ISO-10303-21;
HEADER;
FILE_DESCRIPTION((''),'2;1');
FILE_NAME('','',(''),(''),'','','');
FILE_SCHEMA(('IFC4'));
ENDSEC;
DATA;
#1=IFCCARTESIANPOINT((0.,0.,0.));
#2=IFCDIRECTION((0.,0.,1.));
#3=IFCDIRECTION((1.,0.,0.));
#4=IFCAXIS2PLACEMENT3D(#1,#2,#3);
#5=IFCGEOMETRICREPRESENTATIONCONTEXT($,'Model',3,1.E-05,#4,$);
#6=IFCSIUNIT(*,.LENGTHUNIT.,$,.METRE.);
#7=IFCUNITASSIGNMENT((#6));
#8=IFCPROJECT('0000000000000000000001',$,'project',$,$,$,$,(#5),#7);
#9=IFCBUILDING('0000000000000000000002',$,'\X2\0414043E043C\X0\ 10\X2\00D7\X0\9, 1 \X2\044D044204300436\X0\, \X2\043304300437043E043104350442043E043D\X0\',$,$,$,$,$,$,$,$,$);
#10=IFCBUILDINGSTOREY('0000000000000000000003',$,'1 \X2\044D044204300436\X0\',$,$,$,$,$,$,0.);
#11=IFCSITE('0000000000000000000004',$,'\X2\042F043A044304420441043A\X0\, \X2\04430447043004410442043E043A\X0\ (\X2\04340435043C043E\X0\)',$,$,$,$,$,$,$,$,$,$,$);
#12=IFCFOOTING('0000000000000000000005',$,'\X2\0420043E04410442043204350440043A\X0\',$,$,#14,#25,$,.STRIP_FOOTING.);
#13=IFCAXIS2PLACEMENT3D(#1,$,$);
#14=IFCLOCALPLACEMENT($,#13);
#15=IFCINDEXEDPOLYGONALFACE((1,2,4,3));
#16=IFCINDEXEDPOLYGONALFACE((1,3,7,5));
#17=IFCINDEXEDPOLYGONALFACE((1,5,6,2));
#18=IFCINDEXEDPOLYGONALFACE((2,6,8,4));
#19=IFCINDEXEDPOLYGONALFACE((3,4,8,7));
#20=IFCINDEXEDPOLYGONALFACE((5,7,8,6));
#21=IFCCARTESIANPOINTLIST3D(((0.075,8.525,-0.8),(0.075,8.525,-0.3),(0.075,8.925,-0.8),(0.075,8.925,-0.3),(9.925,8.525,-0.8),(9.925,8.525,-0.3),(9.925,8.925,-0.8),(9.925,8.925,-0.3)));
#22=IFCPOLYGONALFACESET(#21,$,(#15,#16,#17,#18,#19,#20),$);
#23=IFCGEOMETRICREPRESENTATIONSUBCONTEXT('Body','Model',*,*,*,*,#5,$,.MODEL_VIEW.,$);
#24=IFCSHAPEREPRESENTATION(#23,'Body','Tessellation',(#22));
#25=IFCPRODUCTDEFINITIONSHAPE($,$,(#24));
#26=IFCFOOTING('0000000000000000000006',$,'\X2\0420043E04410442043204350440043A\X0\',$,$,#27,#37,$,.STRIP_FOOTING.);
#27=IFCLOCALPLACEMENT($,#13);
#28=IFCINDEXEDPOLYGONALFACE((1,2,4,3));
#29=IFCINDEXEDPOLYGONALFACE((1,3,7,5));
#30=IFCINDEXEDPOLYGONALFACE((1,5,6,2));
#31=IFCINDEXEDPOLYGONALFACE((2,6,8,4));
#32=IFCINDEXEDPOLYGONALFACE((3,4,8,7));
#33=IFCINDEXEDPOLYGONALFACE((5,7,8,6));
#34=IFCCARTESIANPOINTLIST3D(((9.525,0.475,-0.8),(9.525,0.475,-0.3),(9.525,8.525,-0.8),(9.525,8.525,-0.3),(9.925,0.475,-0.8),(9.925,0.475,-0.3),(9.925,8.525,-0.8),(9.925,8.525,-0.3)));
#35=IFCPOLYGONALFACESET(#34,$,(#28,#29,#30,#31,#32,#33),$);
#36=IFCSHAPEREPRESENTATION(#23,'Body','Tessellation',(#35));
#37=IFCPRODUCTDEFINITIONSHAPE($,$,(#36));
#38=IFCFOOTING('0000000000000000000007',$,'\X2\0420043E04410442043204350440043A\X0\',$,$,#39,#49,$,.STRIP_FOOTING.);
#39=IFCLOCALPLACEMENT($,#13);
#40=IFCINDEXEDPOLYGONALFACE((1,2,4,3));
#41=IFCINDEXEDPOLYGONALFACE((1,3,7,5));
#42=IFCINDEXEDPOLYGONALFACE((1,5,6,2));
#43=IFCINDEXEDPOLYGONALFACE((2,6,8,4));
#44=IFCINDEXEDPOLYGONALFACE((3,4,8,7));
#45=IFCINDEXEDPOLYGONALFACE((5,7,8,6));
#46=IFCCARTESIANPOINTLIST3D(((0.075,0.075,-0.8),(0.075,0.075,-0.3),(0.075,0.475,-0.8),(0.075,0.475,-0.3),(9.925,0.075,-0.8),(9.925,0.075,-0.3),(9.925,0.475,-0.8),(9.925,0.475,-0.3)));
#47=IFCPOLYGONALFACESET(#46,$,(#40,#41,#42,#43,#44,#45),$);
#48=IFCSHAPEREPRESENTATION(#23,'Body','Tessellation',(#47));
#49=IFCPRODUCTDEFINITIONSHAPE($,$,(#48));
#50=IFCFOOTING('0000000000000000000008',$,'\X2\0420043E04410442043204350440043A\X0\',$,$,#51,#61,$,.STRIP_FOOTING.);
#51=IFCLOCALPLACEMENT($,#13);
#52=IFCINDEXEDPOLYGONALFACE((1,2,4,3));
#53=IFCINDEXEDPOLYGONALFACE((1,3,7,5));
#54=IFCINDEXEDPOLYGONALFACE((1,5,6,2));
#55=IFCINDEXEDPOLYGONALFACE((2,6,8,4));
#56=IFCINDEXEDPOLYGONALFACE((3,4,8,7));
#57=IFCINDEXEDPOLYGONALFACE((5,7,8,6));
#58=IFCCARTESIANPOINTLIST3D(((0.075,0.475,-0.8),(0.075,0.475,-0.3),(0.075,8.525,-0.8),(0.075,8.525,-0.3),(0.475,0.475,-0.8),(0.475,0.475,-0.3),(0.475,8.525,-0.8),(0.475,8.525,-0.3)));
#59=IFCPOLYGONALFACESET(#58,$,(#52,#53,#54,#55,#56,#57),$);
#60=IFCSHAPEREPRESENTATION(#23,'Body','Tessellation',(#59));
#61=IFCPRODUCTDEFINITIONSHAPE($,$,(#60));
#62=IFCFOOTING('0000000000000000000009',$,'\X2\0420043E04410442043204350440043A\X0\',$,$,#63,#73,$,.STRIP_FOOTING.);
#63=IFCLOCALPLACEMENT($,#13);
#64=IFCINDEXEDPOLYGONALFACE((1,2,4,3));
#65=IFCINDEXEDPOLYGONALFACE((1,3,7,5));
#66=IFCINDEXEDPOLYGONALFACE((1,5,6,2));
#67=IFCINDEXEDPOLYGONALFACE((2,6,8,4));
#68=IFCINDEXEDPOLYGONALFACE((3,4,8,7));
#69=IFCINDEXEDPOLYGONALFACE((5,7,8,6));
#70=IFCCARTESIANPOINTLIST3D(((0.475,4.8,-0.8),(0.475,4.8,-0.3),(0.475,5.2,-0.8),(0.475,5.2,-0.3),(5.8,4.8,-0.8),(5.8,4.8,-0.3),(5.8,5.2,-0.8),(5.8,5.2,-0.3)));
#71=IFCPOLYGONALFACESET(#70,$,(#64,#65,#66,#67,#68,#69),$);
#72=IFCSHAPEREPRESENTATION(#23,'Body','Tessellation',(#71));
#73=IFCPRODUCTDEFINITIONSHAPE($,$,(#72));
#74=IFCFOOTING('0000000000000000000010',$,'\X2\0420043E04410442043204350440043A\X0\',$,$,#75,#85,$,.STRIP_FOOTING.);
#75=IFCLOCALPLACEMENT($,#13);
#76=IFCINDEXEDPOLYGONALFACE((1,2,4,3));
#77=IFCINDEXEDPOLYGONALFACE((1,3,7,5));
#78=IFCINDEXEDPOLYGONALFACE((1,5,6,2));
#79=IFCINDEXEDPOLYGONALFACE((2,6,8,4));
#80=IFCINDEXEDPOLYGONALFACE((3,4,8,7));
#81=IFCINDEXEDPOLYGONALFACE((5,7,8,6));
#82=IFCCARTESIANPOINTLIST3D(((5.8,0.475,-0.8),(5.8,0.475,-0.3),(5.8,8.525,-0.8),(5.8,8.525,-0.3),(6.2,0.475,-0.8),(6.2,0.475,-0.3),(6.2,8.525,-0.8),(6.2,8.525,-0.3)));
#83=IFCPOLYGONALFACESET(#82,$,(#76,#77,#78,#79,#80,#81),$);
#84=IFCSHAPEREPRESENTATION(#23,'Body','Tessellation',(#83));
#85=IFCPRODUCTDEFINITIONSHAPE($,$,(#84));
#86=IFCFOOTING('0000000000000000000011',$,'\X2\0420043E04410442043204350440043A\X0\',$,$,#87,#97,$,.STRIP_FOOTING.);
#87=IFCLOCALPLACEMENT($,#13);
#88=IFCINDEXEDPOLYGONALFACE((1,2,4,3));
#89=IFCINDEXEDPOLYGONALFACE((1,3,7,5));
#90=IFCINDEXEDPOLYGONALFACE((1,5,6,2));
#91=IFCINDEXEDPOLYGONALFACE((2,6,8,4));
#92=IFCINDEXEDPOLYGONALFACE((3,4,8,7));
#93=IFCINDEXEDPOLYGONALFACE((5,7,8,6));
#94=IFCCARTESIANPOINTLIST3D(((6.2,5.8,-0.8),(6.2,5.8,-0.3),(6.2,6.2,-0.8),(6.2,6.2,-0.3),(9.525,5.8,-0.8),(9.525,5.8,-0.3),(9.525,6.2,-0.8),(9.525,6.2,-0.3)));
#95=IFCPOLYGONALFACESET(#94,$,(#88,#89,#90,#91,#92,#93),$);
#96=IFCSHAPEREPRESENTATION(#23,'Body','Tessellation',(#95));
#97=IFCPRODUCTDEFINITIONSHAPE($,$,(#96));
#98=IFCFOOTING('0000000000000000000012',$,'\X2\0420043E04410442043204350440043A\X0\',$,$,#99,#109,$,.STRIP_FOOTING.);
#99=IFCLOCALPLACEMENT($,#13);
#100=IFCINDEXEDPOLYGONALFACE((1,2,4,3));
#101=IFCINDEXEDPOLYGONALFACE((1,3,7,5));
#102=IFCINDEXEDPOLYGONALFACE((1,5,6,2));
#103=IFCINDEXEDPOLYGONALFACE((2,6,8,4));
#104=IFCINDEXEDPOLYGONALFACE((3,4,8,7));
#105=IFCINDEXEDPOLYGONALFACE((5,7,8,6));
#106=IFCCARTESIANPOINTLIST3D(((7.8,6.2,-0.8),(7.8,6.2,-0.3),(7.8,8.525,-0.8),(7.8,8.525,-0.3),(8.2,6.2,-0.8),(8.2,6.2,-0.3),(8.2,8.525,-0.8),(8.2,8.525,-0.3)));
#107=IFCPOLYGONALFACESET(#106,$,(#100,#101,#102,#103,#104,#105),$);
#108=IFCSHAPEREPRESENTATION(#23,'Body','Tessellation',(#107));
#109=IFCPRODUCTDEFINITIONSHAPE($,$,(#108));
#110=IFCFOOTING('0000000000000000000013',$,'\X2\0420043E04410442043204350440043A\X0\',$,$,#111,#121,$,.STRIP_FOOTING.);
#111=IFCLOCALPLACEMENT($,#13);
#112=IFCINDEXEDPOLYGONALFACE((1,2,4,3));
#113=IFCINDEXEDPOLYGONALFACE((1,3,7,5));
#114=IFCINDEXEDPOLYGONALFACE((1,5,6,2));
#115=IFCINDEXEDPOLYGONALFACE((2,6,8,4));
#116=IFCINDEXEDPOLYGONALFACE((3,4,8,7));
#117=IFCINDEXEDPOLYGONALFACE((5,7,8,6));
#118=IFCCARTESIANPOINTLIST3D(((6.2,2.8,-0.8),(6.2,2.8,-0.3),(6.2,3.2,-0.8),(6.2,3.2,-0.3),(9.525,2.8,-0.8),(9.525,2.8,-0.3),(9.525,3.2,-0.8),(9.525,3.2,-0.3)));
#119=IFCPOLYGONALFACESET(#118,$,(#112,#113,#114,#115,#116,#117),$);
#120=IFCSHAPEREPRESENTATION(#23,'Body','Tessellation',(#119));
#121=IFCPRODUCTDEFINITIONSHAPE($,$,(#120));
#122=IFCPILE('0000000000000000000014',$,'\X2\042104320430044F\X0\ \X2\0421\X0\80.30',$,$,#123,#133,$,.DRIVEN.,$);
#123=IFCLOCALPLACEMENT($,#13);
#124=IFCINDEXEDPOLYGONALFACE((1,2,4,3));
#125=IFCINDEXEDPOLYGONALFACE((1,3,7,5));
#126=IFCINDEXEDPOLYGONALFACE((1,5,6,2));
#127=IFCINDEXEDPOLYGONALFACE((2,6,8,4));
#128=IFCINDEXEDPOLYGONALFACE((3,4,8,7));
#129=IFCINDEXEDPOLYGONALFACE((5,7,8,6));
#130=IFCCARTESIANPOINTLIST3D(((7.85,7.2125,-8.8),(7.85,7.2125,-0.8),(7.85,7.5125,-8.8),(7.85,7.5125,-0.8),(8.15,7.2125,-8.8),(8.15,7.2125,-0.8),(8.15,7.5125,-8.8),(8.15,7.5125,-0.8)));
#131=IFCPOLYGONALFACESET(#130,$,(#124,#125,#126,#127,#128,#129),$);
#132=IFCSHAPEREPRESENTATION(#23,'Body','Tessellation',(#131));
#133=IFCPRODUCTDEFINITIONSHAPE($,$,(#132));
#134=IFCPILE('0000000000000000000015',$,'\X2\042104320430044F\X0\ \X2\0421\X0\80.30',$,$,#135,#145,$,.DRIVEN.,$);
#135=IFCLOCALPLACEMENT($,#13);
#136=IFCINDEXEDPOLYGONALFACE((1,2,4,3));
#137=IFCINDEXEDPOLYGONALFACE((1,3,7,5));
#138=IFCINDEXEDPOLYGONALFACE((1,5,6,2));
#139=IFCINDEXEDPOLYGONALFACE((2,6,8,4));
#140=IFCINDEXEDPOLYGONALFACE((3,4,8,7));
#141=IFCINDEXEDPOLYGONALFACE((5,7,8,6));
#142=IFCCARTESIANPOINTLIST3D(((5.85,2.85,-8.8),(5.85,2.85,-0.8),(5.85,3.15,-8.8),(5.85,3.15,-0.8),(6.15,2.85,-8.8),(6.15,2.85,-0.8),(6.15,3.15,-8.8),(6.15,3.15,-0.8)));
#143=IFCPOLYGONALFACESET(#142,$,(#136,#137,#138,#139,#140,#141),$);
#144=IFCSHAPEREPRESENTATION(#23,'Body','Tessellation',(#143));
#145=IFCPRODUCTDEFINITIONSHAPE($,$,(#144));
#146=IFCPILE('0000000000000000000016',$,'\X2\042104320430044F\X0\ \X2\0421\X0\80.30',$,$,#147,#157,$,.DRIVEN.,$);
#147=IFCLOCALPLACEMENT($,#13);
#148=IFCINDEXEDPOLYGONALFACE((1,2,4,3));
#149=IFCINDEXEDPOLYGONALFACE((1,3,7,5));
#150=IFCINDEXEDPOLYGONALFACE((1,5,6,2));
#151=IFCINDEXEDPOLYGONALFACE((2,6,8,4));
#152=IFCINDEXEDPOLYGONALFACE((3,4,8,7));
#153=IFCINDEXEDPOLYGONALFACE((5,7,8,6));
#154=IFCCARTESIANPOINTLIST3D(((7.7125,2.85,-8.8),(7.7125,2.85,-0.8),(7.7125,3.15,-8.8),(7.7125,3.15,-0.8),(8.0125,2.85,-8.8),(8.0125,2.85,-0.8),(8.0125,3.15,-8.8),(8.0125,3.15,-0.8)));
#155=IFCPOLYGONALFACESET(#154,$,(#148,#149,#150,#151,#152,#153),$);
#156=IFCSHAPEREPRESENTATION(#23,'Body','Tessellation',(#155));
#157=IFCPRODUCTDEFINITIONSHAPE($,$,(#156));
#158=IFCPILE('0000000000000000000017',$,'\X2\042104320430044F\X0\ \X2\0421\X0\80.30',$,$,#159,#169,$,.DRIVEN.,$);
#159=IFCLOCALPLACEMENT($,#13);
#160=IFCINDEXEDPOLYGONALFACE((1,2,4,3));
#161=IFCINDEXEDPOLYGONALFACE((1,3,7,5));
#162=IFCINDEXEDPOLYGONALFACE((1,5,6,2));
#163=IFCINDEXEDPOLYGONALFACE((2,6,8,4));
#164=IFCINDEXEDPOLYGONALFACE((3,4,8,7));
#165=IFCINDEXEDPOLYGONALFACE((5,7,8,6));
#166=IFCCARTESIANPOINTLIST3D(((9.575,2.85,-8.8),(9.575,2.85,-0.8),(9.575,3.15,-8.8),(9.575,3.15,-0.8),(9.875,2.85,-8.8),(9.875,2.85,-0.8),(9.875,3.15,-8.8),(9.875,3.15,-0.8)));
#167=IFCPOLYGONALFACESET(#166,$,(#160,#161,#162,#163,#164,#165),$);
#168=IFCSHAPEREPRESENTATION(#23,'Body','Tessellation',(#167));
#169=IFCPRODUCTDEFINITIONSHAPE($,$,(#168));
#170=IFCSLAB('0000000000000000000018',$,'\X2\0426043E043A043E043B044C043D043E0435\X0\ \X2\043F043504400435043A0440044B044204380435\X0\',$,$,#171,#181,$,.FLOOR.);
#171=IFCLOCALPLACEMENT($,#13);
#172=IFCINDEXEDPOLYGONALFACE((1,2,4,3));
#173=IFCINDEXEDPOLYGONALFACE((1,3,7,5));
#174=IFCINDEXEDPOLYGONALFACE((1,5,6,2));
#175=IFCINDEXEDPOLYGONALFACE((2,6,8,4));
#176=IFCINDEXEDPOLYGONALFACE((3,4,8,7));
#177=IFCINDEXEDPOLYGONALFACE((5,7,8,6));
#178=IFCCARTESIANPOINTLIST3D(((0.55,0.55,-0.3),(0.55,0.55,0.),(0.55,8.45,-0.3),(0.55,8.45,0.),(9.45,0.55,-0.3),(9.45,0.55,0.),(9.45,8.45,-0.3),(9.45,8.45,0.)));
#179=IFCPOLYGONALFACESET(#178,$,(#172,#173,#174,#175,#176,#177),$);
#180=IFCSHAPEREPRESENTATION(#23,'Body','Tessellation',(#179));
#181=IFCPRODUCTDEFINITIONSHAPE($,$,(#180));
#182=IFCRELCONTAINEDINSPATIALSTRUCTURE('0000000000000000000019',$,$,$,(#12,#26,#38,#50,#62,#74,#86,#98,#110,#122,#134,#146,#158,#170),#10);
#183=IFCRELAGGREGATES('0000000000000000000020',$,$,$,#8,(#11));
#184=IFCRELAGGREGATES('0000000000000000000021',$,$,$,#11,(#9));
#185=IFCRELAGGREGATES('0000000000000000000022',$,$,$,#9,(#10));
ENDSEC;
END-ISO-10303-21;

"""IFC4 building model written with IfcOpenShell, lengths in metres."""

from ifc_helpers import new_model, si_unit, frame, origin_with_axes, place, context, subcontext, project, spatial, indexed_curve, rectangle, outline, extrude, element, save


model = new_model("IFC4")

# Units and contexts
model_context = context("Model", 3, precision=1e-05, world=origin_with_axes())
body_context = subcontext(model_context, "Body", "Model", "MODEL_VIEW")
ifc_project = project(units=[si_unit("LENGTHUNIT", "METRE")], contexts=[model_context])

# Site, building, storey
site = spatial("IfcSite", under=ifc_project, Name="Якутск, участок (демо)")
building = spatial("IfcBuilding", under=site, Name="Дом 10×9, 1 этаж, газобетон")
storey = spatial("IfcBuildingStorey", under=building, Name="1 этаж", Elevation=0.0)

# Footings
footing_1_placement = place(None, frame((0.075, 8.525, -0.8), z_axis=(0.0, 0.0, 1.0), x_axis=(1.0, 0.0, 0.0)))
element("IfcFooting", 1, at=footing_1_placement, inside=storey, Name="Ростверк", PredefinedType="STRIP_FOOTING", context=body_context, shape_type="SweptSolid", body=[
    extrude(outline(indexed_curve([(0.0, 0.0), (0.0, 0.4), (9.85, 0.4), (9.85, 0.0), (0.0, 0.0)], self_intersect=False)), origin_with_axes(), (0.0, 0.0, 1.0), 0.5),
])
footing_2_placement = place(None, frame((9.925, 0.475, -0.8), z_axis=(0.0, 0.0, 1.0), x_axis=(0.0, 1.0, 0.0)))
element("IfcFooting", 2, at=footing_2_placement, inside=storey, Name="Ростверк", PredefinedType="STRIP_FOOTING", context=body_context, shape_type="SweptSolid", body=[
    extrude(outline(indexed_curve([(0.0, 0.0), (0.0, 0.4), (8.05, 0.4), (8.05, 0.0), (0.0, 0.0)], self_intersect=False)), origin_with_axes(), (0.0, 0.0, 1.0), 0.5),
])
footing_3_placement = place(None, frame((0.075, 0.075, -0.8), z_axis=(0.0, 0.0, 1.0), x_axis=(1.0, 0.0, 0.0)))
element("IfcFooting", 3, at=footing_3_placement, inside=storey, Name="Ростверк", PredefinedType="STRIP_FOOTING", context=body_context, shape_type="SweptSolid", body=[
    extrude(outline(indexed_curve([(0.0, 0.0), (0.0, 0.4), (9.85, 0.4), (9.85, 0.0), (0.0, 0.0)], self_intersect=False)), origin_with_axes(), (0.0, 0.0, 1.0), 0.5),
])
footing_4_placement = place(None, frame((0.475, 0.475, -0.8), z_axis=(0.0, 0.0, 1.0), x_axis=(0.0, 1.0, 0.0)))
element("IfcFooting", 4, at=footing_4_placement, inside=storey, Name="Ростверк", PredefinedType="STRIP_FOOTING", context=body_context, shape_type="SweptSolid", body=[
    extrude(outline(indexed_curve([(0.0, 0.0), (0.0, 0.4), (8.05, 0.4), (8.05, 0.0), (0.0, 0.0)], self_intersect=False)), origin_with_axes(), (0.0, 0.0, 1.0), 0.5),
])
footing_5_placement = place(None, frame((0.475, 4.8, -0.8), z_axis=(0.0, 0.0, 1.0), x_axis=(1.0, 0.0, 0.0)))
element("IfcFooting", 5, at=footing_5_placement, inside=storey, Name="Ростверк", PredefinedType="STRIP_FOOTING", context=body_context, shape_type="SweptSolid", body=[
    extrude(outline(indexed_curve([(0.0, 0.0), (0.0, 0.4), (5.325, 0.4), (5.325, 0.0), (0.0, 0.0)], self_intersect=False)), origin_with_axes(), (0.0, 0.0, 1.0), 0.5),
])
footing_6_placement = place(None, frame((6.2, 0.475, -0.8), z_axis=(0.0, 0.0, 1.0), x_axis=(0.0, 1.0, 0.0)))
element("IfcFooting", 6, at=footing_6_placement, inside=storey, Name="Ростверк", PredefinedType="STRIP_FOOTING", context=body_context, shape_type="SweptSolid", body=[
    extrude(outline(indexed_curve([(0.0, 0.0), (0.0, 0.4), (8.05, 0.4), (8.05, 0.0), (0.0, 0.0)], self_intersect=False)), origin_with_axes(), (0.0, 0.0, 1.0), 0.5),
])
footing_7_placement = place(None, frame((6.2, 5.8, -0.8), z_axis=(0.0, 0.0, 1.0), x_axis=(1.0, 0.0, 0.0)))
element("IfcFooting", 7, at=footing_7_placement, inside=storey, Name="Ростверк", PredefinedType="STRIP_FOOTING", context=body_context, shape_type="SweptSolid", body=[
    extrude(outline(indexed_curve([(0.0, 0.0), (0.0, 0.4), (3.325, 0.4), (3.325, 0.0), (0.0, 0.0)], self_intersect=False)), origin_with_axes(), (0.0, 0.0, 1.0), 0.5),
])
footing_8_placement = place(None, frame((8.2, 6.2, -0.8), z_axis=(0.0, 0.0, 1.0), x_axis=(0.0, 1.0, 0.0)))
element("IfcFooting", 8, at=footing_8_placement, inside=storey, Name="Ростверк", PredefinedType="STRIP_FOOTING", context=body_context, shape_type="SweptSolid", body=[
    extrude(outline(indexed_curve([(0.0, 0.0), (0.0, 0.4), (2.325, 0.4), (2.325, 0.0), (0.0, 0.0)], self_intersect=False)), origin_with_axes(), (0.0, 0.0, 1.0), 0.5),
])
footing_9_placement = place(None, frame((6.2, 2.8, -0.8), z_axis=(0.0, 0.0, 1.0), x_axis=(1.0, 0.0, 0.0)))
element("IfcFooting", 9, at=footing_9_placement, inside=storey, Name="Ростверк", PredefinedType="STRIP_FOOTING", context=body_context, shape_type="SweptSolid", body=[
    extrude(outline(indexed_curve([(0.0, 0.0), (0.0, 0.4), (3.325, 0.4), (3.325, 0.0), (0.0, 0.0)], self_intersect=False)), origin_with_axes(), (0.0, 0.0, 1.0), 0.5),
])

# Piles
for number, where, z_axis, x_axis, name in (
    (10, (8.0, 7.3625, -8.8), (0.0, 0.0, 1.0), (1.0, 0.0, 0.0), "Свая С80.30"),
    (11, (6.0, 3.0, -8.8), (0.0, 0.0, 1.0), (1.0, 0.0, 0.0), "Свая С80.30"),
    (12, (7.8625, 3.0, -8.8), (0.0, 0.0, 1.0), (1.0, 0.0, 0.0), "Свая С80.30"),
    (13, (9.725, 3.0, -8.8), (0.0, 0.0, 1.0), (1.0, 0.0, 0.0), "Свая С80.30"),
):
    element("IfcPile", number, at=place(None, frame(where, z_axis=z_axis, x_axis=x_axis)), inside=storey, Name=name, PredefinedType="DRIVEN", context=body_context, shape_type="SweptSolid", body=[
        extrude(rectangle(XDim=0.3, YDim=0.3), origin_with_axes(), (0.0, 0.0, 1.0), 8.0),
    ])

# Slab
slab_placement = place(None, frame((0.0, 0.0, -0.3), z_axis=(0.0, 0.0, 1.0), x_axis=(1.0, 0.0, 0.0)))
element("IfcSlab", 14, at=slab_placement, inside=storey, Name="Цокольное перекрытие", PredefinedType="FLOOR", context=body_context, shape_type="SweptSolid", body=[
    extrude(outline(indexed_curve([(0.55, 0.55), (9.45, 0.55), (9.45, 8.45), (0.55, 8.45)])), None, (0.0, 0.0, 1.0), 0.3),
])

save(model, "model.ifc")
